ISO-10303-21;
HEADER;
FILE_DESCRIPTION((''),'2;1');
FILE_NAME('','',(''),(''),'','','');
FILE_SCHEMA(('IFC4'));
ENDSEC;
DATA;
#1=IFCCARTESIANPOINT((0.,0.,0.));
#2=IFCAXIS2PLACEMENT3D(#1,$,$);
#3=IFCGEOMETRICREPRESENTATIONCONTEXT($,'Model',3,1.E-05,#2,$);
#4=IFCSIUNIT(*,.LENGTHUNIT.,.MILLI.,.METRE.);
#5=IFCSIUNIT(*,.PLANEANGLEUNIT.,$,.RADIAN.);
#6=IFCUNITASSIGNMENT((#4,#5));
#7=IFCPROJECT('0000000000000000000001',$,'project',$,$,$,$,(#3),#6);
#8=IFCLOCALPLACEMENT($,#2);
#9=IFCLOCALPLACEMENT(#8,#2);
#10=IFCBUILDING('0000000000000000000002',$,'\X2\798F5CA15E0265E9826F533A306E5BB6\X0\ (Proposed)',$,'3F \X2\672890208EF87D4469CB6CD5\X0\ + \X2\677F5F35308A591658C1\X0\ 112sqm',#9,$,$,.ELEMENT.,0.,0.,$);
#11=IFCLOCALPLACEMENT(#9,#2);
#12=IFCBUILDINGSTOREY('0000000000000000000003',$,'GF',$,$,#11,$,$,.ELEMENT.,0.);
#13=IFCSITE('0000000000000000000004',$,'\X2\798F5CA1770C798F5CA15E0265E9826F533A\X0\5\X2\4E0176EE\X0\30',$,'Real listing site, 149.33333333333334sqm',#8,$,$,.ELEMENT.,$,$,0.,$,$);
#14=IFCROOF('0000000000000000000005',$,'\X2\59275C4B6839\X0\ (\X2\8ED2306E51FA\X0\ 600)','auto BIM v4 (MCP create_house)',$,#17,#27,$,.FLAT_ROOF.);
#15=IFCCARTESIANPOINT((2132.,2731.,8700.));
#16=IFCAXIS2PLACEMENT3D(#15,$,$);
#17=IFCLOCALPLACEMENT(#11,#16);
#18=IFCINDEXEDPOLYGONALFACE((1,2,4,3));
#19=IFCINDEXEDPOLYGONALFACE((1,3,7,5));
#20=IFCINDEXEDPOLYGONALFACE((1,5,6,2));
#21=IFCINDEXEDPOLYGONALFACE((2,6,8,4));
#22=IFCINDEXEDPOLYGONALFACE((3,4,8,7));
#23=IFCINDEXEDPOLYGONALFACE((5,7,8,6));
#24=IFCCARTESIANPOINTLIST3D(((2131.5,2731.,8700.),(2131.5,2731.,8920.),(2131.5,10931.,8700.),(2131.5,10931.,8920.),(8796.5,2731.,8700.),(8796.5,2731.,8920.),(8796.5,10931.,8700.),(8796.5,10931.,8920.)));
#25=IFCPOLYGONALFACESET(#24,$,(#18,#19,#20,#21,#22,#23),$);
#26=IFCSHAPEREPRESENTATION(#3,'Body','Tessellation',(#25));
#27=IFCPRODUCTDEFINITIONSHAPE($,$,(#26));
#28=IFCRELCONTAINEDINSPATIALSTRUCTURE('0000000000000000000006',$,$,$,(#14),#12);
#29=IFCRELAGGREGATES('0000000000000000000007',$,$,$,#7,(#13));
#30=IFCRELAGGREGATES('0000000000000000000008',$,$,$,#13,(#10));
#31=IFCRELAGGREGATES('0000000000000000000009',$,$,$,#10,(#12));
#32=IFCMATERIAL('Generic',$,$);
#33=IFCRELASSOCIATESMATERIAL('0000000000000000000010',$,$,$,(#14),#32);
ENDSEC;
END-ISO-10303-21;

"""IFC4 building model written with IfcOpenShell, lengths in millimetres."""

from ifc_helpers import new_model, si_unit, frame, frame_2d, origin, place, context, project, spatial, rectangle, extrude, material, element, save


model = new_model("IFC4")

# Units and contexts
model_context = context("Model", 3, precision=1e-05, world=origin())
ifc_project = project(units=[si_unit("LENGTHUNIT", "METRE", prefix="MILLI"), si_unit("PLANEANGLEUNIT", "RADIAN")], contexts=[model_context])

# Site, building, storey
site_placement = place(None, origin())
site = spatial("IfcSite", under=ifc_project, at=site_placement, Name="福岡県福岡市早良区5丁目30", ObjectType="Real listing site, 149.33333333333334sqm", CompositionType="ELEMENT", RefElevation=0.0)
building_placement = place(site_placement, origin())
building = spatial("IfcBuilding", under=site, at=building_placement, Name="福岡市早良区の家 (Proposed)", ObjectType="3F 木造軸組構法 + 板張り外壁 112sqm", CompositionType="ELEMENT", ElevationOfRefHeight=0.0, ElevationOfTerrain=0.0)
storey_placement = place(building_placement, origin())
storey = spatial("IfcBuildingStorey", under=building, at=storey_placement, Name="GF", CompositionType="ELEMENT", Elevation=0.0)

# Shared definitions
ifc_material = material(Name="Generic")

# Roof
roof_placement = place(storey_placement, frame((2132.0, 2731.0, 8700.0)))
element("IfcRoof", 1, at=roof_placement, inside=storey, material=ifc_material, Name="大屋根 (軒の出 600)", Description="auto BIM v4 (MCP create_house)", PredefinedType="FLAT_ROOF", context=model_context, shape_type="SweptSolid", body=[
    extrude(rectangle(XDim=6665.0, YDim=8200.0, at=frame_2d((3332.0, 4100.0))), frame((2132.0, 2731.0, 8700.0)), (0.0, 0.0, 1.0), 220.0),
])

save(model, "model.ifc")
